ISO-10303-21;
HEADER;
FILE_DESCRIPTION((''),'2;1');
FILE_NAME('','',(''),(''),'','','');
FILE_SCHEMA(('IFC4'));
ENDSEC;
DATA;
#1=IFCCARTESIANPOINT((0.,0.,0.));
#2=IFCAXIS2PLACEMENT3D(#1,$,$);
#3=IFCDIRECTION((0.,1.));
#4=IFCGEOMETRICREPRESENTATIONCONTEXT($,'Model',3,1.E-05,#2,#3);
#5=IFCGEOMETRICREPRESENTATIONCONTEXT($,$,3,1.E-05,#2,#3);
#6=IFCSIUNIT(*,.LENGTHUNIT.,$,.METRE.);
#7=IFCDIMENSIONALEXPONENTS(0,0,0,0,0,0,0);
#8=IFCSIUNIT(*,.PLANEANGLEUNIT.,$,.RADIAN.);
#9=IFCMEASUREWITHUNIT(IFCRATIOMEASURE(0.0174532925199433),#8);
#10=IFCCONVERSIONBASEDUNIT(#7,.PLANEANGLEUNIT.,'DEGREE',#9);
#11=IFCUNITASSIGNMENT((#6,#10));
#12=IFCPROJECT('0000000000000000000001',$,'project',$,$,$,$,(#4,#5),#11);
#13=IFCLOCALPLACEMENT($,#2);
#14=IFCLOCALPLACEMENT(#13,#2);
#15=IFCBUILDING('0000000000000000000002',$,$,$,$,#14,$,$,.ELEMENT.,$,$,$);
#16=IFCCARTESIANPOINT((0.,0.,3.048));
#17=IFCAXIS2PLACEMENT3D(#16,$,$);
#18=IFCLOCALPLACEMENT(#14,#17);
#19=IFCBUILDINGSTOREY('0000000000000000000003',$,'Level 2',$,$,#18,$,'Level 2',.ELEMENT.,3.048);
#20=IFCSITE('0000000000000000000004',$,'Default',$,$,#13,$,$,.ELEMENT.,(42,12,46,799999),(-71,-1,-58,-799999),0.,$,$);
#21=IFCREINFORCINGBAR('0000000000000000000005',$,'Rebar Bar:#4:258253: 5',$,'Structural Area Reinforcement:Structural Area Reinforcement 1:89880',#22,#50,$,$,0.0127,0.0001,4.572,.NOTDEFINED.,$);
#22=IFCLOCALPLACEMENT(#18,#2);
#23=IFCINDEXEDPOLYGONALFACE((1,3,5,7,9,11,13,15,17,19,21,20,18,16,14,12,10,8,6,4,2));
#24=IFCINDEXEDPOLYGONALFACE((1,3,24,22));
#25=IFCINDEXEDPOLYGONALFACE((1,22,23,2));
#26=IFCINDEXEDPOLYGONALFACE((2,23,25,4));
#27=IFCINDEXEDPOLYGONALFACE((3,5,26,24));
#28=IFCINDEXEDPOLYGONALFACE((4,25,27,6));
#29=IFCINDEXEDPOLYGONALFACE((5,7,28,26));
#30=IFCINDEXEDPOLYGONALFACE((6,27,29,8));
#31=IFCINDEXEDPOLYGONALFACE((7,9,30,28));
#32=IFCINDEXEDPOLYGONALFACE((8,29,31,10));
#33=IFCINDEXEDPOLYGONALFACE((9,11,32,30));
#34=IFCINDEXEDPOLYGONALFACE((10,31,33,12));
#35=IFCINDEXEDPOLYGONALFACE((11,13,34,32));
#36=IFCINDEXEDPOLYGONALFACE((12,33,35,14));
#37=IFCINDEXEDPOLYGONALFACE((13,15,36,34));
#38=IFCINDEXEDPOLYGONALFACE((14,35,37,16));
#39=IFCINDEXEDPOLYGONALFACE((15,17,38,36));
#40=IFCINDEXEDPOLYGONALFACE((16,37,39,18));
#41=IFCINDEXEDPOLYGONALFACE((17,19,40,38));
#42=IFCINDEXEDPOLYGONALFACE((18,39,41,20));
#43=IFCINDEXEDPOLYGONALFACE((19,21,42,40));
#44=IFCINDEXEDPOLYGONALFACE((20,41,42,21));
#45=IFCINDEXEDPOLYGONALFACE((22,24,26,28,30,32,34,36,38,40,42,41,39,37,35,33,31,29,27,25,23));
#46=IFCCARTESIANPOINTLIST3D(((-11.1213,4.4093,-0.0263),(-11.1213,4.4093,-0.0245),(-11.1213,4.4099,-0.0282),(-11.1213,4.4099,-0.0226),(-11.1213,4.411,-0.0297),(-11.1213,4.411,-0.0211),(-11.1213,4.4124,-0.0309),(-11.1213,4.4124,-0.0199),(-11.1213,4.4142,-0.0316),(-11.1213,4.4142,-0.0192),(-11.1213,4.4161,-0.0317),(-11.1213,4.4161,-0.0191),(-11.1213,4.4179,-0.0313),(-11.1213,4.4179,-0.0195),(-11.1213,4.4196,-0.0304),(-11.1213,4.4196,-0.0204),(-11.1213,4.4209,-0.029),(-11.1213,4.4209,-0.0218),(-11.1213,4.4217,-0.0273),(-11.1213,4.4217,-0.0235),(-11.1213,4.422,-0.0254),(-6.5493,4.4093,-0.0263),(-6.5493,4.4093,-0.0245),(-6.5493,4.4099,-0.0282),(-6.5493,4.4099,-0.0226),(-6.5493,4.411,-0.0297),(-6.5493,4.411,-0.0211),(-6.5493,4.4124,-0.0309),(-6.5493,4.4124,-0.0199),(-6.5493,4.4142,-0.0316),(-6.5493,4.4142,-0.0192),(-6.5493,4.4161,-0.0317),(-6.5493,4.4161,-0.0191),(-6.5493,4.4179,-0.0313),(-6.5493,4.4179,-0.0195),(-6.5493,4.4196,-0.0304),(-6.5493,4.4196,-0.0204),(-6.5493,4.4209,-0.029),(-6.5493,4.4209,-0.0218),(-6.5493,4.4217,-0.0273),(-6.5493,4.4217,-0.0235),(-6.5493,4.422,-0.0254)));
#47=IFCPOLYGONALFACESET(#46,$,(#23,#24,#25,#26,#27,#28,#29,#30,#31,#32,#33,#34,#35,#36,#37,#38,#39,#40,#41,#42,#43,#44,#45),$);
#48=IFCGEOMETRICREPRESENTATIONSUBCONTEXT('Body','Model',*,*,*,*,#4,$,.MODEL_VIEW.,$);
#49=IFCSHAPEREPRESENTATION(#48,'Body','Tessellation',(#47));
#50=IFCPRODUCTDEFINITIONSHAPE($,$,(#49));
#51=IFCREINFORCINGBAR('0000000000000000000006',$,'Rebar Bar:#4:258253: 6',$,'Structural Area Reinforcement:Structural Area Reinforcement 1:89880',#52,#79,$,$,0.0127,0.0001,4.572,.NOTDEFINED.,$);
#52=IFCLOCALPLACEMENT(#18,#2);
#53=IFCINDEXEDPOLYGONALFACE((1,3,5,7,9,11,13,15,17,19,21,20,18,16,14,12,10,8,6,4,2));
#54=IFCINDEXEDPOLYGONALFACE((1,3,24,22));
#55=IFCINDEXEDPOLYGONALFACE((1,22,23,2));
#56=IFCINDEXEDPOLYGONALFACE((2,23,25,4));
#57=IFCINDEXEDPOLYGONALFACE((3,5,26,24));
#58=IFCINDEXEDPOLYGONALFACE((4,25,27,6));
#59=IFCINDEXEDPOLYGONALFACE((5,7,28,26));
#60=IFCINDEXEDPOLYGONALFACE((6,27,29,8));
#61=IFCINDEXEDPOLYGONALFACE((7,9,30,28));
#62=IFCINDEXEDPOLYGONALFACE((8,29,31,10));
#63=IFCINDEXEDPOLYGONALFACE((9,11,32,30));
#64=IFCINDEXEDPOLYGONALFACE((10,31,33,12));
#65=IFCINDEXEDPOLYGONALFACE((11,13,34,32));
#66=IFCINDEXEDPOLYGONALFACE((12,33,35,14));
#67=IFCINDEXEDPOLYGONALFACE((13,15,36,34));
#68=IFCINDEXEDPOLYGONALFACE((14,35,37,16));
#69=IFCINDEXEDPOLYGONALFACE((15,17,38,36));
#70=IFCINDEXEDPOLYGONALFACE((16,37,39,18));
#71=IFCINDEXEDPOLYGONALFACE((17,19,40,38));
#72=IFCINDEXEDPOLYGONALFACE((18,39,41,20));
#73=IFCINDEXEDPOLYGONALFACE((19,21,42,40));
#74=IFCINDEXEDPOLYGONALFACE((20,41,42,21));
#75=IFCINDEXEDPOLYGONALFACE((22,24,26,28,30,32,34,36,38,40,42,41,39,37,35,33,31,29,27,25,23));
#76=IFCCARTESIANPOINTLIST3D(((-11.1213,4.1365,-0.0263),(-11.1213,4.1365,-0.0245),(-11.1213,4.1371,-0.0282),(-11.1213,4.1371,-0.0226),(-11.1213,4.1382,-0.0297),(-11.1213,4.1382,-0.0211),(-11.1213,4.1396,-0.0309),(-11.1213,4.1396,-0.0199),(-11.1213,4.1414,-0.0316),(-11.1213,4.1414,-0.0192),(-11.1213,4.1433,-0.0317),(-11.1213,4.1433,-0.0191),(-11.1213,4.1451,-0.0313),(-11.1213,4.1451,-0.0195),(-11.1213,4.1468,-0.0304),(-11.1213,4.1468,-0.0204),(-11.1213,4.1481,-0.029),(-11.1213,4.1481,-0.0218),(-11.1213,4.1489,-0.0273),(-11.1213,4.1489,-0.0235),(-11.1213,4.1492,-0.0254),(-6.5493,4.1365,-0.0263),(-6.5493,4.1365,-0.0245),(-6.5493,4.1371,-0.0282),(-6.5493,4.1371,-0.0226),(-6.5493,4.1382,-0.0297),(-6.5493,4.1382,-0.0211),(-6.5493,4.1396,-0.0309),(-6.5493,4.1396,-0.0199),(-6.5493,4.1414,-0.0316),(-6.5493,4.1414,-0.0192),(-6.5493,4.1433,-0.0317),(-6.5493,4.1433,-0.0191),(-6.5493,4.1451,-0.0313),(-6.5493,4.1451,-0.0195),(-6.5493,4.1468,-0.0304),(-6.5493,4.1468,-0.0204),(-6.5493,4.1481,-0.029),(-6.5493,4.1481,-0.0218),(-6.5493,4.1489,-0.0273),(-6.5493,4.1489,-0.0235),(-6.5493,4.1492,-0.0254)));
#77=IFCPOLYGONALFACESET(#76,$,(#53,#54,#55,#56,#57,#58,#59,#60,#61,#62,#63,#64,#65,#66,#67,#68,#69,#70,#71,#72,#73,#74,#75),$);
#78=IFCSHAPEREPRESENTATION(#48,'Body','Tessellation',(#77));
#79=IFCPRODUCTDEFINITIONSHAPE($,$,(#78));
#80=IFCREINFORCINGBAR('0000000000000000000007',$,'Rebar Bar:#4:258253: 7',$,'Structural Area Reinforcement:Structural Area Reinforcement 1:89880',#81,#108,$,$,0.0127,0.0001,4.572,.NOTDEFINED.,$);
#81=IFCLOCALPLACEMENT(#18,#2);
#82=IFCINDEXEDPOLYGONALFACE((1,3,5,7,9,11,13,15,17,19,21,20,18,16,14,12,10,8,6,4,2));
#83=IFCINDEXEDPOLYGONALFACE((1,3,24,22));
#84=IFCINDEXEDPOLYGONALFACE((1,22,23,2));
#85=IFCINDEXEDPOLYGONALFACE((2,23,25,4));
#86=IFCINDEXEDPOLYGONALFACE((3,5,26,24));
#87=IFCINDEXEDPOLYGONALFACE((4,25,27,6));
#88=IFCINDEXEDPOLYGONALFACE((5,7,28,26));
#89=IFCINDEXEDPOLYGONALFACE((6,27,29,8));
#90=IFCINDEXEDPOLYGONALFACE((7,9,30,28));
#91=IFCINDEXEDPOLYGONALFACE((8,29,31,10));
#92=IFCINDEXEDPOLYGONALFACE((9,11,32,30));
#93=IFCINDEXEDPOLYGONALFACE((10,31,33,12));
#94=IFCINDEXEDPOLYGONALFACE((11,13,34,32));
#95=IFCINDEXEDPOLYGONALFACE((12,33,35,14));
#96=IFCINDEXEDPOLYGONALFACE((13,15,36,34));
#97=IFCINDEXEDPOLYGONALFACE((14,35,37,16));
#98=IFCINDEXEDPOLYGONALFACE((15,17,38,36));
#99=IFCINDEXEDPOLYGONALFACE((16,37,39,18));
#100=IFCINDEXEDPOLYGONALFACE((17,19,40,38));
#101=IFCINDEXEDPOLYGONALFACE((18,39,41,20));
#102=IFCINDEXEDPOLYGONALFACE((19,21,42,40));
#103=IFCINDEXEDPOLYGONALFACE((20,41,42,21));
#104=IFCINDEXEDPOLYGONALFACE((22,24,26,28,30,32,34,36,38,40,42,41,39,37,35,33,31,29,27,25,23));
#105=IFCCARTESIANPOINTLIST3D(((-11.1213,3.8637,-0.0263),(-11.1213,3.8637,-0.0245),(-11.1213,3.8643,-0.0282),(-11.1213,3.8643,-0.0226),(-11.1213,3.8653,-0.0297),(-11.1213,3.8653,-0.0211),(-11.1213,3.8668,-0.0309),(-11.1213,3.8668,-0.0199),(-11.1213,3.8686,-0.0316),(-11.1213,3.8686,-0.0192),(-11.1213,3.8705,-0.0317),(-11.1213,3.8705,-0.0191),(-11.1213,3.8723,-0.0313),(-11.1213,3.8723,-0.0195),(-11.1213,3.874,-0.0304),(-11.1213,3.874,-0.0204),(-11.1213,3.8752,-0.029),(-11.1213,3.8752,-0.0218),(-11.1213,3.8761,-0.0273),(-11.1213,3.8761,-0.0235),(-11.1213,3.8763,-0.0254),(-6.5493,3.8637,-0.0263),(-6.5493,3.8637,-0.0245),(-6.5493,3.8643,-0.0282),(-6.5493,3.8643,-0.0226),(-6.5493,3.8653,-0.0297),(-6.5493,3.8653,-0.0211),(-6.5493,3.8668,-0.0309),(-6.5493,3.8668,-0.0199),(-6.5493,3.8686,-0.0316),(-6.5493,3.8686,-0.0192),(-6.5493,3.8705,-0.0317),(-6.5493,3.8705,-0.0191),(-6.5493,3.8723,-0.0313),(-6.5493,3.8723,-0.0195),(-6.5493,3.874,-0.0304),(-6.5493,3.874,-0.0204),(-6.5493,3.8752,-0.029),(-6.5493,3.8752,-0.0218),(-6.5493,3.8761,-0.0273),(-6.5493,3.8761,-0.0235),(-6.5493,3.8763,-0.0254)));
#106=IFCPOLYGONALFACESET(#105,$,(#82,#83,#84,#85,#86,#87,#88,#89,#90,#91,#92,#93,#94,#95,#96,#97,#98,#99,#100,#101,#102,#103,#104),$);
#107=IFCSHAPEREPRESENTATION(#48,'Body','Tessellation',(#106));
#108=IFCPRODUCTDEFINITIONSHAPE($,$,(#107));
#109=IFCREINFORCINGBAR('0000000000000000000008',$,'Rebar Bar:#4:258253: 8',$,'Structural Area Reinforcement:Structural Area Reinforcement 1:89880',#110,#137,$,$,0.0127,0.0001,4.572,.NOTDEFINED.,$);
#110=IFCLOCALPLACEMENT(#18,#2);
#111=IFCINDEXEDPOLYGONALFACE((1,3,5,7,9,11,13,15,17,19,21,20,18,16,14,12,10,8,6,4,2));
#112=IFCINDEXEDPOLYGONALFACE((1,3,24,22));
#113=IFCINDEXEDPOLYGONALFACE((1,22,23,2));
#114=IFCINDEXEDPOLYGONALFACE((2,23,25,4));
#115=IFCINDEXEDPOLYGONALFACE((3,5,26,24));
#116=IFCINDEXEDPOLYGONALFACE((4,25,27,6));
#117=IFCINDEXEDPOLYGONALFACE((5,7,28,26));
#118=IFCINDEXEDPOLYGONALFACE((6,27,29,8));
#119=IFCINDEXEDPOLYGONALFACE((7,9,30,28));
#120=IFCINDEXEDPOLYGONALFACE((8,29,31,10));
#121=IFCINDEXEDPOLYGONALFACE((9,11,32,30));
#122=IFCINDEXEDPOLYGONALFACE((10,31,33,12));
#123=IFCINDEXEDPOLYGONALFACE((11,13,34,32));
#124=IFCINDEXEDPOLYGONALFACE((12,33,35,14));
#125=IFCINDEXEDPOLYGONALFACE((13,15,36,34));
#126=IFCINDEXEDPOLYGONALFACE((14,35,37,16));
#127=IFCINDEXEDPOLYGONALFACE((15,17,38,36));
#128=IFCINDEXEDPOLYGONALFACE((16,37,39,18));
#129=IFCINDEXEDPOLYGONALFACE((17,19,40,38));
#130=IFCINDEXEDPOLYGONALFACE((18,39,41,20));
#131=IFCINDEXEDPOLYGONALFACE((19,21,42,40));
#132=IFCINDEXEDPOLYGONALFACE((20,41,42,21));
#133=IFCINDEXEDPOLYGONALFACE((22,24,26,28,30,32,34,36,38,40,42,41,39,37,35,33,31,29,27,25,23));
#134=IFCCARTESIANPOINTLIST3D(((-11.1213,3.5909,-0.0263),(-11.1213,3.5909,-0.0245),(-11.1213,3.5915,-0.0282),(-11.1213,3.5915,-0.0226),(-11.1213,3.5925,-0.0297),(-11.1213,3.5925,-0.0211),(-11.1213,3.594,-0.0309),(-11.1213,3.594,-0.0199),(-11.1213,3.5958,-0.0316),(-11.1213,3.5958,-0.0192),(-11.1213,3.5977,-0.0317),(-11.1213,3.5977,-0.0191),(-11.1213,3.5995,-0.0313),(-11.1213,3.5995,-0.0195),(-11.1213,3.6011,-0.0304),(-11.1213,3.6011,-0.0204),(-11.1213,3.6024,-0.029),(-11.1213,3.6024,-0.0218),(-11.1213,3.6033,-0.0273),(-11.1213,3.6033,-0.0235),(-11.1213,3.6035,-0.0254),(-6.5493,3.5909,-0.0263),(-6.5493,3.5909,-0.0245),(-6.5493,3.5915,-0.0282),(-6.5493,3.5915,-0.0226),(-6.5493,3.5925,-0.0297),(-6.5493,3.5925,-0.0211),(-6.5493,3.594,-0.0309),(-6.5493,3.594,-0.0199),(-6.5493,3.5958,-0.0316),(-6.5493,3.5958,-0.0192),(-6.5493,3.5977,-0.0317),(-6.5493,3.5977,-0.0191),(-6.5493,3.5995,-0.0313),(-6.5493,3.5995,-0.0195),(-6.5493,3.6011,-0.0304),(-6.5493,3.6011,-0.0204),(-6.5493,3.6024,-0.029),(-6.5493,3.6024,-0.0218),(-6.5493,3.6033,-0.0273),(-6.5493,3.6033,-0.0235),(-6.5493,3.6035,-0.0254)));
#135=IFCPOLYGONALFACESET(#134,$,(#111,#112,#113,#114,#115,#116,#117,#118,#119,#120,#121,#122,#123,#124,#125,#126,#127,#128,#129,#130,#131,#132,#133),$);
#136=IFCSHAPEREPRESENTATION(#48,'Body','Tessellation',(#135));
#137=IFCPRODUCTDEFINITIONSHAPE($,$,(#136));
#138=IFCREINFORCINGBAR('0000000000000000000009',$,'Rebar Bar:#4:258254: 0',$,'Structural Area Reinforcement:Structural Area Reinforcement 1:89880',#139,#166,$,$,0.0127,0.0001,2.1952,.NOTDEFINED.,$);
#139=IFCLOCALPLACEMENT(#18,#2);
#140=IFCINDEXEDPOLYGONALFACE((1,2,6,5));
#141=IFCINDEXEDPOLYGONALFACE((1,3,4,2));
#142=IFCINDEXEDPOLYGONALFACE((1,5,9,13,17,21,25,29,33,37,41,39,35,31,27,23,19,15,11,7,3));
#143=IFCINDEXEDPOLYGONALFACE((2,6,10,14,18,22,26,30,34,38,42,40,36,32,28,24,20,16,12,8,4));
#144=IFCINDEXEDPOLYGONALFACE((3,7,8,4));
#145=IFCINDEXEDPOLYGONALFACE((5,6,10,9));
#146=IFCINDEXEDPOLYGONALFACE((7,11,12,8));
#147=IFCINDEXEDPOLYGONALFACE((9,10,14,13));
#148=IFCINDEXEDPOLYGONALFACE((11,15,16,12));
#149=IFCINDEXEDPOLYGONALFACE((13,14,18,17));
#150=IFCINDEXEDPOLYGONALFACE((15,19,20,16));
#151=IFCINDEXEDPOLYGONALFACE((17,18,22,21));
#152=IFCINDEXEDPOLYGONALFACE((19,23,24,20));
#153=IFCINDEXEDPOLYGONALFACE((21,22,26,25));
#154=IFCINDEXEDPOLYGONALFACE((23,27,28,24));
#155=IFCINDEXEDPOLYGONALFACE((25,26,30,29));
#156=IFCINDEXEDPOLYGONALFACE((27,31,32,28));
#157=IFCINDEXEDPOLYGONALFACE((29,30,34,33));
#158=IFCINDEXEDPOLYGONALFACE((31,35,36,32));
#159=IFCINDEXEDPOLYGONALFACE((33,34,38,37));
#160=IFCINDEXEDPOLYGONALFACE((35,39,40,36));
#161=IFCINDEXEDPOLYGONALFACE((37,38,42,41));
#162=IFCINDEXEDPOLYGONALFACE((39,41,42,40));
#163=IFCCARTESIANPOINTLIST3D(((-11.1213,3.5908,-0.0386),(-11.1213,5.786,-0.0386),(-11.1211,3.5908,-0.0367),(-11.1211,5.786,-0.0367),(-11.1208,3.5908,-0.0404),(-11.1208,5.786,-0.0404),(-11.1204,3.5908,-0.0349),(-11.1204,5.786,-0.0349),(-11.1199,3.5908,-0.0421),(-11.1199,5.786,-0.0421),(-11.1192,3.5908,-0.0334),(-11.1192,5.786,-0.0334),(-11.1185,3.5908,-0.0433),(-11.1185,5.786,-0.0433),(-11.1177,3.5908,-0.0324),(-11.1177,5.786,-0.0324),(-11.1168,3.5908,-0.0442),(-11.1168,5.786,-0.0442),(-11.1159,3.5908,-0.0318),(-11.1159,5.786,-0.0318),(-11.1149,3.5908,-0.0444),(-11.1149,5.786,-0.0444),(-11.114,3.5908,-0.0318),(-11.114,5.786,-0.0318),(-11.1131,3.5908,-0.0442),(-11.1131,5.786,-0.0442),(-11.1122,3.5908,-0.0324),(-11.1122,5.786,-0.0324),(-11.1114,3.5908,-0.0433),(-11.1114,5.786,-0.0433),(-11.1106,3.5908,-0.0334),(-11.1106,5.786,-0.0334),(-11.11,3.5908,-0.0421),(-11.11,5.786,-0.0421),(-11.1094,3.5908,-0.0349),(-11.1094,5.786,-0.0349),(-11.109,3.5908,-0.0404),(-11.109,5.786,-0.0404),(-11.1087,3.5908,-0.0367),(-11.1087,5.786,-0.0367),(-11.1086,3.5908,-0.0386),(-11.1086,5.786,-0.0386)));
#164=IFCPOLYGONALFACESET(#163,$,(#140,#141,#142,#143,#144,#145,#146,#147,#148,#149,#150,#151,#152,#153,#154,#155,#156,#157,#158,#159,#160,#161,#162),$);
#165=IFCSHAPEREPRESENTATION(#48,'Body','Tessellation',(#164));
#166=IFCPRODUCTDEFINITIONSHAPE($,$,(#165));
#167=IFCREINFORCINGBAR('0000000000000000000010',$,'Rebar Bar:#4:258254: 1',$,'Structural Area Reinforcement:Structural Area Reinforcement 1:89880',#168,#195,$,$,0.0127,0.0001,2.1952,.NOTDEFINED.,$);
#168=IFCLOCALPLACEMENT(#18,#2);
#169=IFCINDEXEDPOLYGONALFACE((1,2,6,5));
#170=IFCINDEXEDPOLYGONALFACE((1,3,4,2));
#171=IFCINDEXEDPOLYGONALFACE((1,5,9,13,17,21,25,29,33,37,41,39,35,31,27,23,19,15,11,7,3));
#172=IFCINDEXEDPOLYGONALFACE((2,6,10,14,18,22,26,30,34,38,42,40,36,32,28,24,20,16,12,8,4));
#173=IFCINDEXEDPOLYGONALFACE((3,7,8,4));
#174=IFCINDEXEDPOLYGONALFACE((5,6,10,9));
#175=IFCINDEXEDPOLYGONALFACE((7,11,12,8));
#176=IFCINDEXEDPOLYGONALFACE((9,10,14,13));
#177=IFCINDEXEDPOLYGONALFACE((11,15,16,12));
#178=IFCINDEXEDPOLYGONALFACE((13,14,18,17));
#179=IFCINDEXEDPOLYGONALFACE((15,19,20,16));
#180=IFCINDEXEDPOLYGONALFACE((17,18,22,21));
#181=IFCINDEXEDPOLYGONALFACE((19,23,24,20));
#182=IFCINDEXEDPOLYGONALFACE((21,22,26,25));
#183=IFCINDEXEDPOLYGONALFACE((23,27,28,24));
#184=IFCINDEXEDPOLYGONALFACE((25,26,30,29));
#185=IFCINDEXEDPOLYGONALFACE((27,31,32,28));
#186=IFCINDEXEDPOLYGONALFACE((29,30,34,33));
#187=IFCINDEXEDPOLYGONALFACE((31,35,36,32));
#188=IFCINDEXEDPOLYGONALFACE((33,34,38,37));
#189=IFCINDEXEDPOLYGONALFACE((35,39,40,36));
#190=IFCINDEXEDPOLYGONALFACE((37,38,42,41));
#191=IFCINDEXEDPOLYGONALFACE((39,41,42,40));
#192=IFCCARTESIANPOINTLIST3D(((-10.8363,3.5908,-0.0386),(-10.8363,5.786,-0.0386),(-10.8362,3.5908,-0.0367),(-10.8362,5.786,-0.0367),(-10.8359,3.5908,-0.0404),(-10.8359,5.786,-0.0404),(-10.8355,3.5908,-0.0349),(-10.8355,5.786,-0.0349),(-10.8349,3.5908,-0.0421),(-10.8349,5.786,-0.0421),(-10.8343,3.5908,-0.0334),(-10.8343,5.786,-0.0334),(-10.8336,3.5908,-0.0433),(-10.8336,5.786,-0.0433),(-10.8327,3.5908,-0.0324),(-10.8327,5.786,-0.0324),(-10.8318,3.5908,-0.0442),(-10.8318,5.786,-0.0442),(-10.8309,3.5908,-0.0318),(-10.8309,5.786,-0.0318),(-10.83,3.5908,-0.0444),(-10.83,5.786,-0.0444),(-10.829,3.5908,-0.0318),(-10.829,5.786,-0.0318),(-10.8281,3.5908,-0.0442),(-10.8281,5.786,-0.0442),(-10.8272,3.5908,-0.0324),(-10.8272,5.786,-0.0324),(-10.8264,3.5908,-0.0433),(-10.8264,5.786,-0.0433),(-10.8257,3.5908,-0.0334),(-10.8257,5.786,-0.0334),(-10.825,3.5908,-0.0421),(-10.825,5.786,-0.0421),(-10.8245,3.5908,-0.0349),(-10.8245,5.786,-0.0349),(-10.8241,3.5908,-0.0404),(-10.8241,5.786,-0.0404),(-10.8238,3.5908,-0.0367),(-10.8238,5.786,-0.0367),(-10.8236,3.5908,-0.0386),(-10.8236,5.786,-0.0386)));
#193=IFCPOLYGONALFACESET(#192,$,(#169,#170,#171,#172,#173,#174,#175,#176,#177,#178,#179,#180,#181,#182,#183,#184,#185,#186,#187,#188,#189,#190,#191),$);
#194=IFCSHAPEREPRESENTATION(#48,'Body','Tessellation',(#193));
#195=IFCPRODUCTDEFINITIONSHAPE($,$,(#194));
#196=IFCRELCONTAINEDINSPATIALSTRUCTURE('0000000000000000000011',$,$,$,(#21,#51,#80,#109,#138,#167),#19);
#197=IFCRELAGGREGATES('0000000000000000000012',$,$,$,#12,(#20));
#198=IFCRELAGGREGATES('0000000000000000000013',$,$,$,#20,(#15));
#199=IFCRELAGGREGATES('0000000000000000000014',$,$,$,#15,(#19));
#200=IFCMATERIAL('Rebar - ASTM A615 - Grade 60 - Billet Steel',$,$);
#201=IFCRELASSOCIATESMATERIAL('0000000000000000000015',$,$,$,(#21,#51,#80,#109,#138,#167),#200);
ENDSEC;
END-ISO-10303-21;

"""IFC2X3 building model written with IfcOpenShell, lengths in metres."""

from ifc_helpers import new_model, entity, si_unit, converted_unit, direction, frame, origin, place, context, subcontext, project, spatial, material, element, save


model = new_model("IFC2X3")

# Units and contexts
model_context = context("Model", 3, precision=1e-05, world=origin(), true_north=direction((0.0, 1.0)))
context_of_model = context(None, 3, precision=1e-05, world=origin(), true_north=direction((0.0, 1.0)))
body_context = subcontext(model_context, "Body", "Model", "MODEL_VIEW")
ifc_project = project(units=[si_unit("LENGTHUNIT", "METRE"), converted_unit("PLANEANGLEUNIT", "DEGREE", entity("IfcRatioMeasure", 0.0174532925199433), si_unit("PLANEANGLEUNIT", "RADIAN"), dimensions=[0, 0, 0, 0, 0, 0, 0])], contexts=[model_context, context_of_model])

# Site, building, storey
site_placement = place(None, origin())
site = spatial("IfcSite", under=ifc_project, at=site_placement, Name="Default", CompositionType="ELEMENT", RefLatitude=(42, 12, 46, 799999), RefLongitude=(-71, -1, -58, -799999), RefElevation=0.0)
building_placement = place(site_placement, origin())
building = spatial("IfcBuilding", under=site, at=building_placement, CompositionType="ELEMENT")
storey_placement = place(building_placement, frame((0.0, 0.0, 3.048)))
storey = spatial("IfcBuildingStorey", under=building, at=storey_placement, Name="Level 2", LongName="Level 2", CompositionType="ELEMENT", Elevation=3.048)

# Reinforcing bars
ifc_material_1 = material(Name="Rebar - ASTM A615 - Grade 60 - Billet Steel")
reinforcing_bar_1_placement = place(storey_placement, origin())
element("IfcReinforcingBar", 1, at=reinforcing_bar_1_placement, inside=storey, material=ifc_material_1, Name="Rebar Bar:#4:258253: 5", ObjectType="Structural Area Reinforcement:Structural Area Reinforcement 1:89880", BarLength=4.572, BarRole="NOTDEFINED", CrossSectionArea=0.0001, NominalDiameter=0.0127, context=body_context, shape_type="AdvancedSweptSolid", body=[
    entity("IfcSweptDiskSolid", entity("IfcCompositeCurve", [entity("IfcCompositeCurveSegment", "CONTINUOUS", True, entity("IfcPolyline", [entity("IfcCartesianPoint", [-11.1213, 4.4156, -0.0254]), entity("IfcCartesianPoint", [-6.5493, 4.4156, -0.0254])]))], False), 0.0063, None, 0.0, 1.0),
])
reinforcing_bar_2_placement = place(storey_placement, origin())
element("IfcReinforcingBar", 2, at=reinforcing_bar_2_placement, inside=storey, material=ifc_material_1, Name="Rebar Bar:#4:258253: 6", ObjectType="Structural Area Reinforcement:Structural Area Reinforcement 1:89880", BarLength=4.572, BarRole="NOTDEFINED", CrossSectionArea=0.0001, NominalDiameter=0.0127, context=body_context, shape_type="AdvancedSweptSolid", body=[
    entity("IfcSweptDiskSolid", entity("IfcCompositeCurve", [entity("IfcCompositeCurveSegment", "CONTINUOUS", True, entity("IfcPolyline", [entity("IfcCartesianPoint", [-11.1213, 4.1428, -0.0254]), entity("IfcCartesianPoint", [-6.5493, 4.1428, -0.0254])]))], False), 0.0063, None, 0.0, 1.0),
])
reinforcing_bar_3_placement = place(storey_placement, origin())
element("IfcReinforcingBar", 3, at=reinforcing_bar_3_placement, inside=storey, material=ifc_material_1, Name="Rebar Bar:#4:258253: 7", ObjectType="Structural Area Reinforcement:Structural Area Reinforcement 1:89880", BarLength=4.572, BarRole="NOTDEFINED", CrossSectionArea=0.0001, NominalDiameter=0.0127, context=body_context, shape_type="AdvancedSweptSolid", body=[
    entity("IfcSweptDiskSolid", entity("IfcCompositeCurve", [entity("IfcCompositeCurveSegment", "CONTINUOUS", True, entity("IfcPolyline", [entity("IfcCartesianPoint", [-11.1213, 3.87, -0.0254]), entity("IfcCartesianPoint", [-6.5493, 3.87, -0.0254])]))], False), 0.0063, None, 0.0, 1.0),
])
reinforcing_bar_4_placement = place(storey_placement, origin())
element("IfcReinforcingBar", 4, at=reinforcing_bar_4_placement, inside=storey, material=ifc_material_1, Name="Rebar Bar:#4:258253: 8", ObjectType="Structural Area Reinforcement:Structural Area Reinforcement 1:89880", BarLength=4.572, BarRole="NOTDEFINED", CrossSectionArea=0.0001, NominalDiameter=0.0127, context=body_context, shape_type="AdvancedSweptSolid", body=[
    entity("IfcSweptDiskSolid", entity("IfcCompositeCurve", [entity("IfcCompositeCurveSegment", "CONTINUOUS", True, entity("IfcPolyline", [entity("IfcCartesianPoint", [-11.1213, 3.5972, -0.0254]), entity("IfcCartesianPoint", [-6.5493, 3.5972, -0.0254])]))], False), 0.0063, None, 0.0, 1.0),
])
reinforcing_bar_5_placement = place(storey_placement, origin())
element("IfcReinforcingBar", 5, at=reinforcing_bar_5_placement, inside=storey, material=ifc_material_1, Name="Rebar Bar:#4:258254: 0", ObjectType="Structural Area Reinforcement:Structural Area Reinforcement 1:89880", BarLength=2.1952, BarRole="NOTDEFINED", CrossSectionArea=0.0001, NominalDiameter=0.0127, context=body_context, shape_type="AdvancedSweptSolid", body=[
    entity("IfcSweptDiskSolid", entity("IfcCompositeCurve", [entity("IfcCompositeCurveSegment", "CONTINUOUS", True, entity("IfcPolyline", [entity("IfcCartesianPoint", [-11.1149, 5.786, -0.0381]), entity("IfcCartesianPoint", [-11.1149, 3.5908, -0.0381])]))], False), 0.0063, None, 0.0, 1.0),
])
reinforcing_bar_6_placement = place(storey_placement, origin())
element("IfcReinforcingBar", 6, at=reinforcing_bar_6_placement, inside=storey, material=ifc_material_1, Name="Rebar Bar:#4:258254: 1", ObjectType="Structural Area Reinforcement:Structural Area Reinforcement 1:89880", BarLength=2.1952, BarRole="NOTDEFINED", CrossSectionArea=0.0001, NominalDiameter=0.0127, context=body_context, shape_type="AdvancedSweptSolid", body=[
    entity("IfcSweptDiskSolid", entity("IfcCompositeCurve", [entity("IfcCompositeCurveSegment", "CONTINUOUS", True, entity("IfcPolyline", [entity("IfcCartesianPoint", [-10.83, 5.786, -0.0381]), entity("IfcCartesianPoint", [-10.83, 3.5908, -0.0381])]))], False), 0.0063, None, 0.0, 1.0),
])

save(model, "model.ifc")
